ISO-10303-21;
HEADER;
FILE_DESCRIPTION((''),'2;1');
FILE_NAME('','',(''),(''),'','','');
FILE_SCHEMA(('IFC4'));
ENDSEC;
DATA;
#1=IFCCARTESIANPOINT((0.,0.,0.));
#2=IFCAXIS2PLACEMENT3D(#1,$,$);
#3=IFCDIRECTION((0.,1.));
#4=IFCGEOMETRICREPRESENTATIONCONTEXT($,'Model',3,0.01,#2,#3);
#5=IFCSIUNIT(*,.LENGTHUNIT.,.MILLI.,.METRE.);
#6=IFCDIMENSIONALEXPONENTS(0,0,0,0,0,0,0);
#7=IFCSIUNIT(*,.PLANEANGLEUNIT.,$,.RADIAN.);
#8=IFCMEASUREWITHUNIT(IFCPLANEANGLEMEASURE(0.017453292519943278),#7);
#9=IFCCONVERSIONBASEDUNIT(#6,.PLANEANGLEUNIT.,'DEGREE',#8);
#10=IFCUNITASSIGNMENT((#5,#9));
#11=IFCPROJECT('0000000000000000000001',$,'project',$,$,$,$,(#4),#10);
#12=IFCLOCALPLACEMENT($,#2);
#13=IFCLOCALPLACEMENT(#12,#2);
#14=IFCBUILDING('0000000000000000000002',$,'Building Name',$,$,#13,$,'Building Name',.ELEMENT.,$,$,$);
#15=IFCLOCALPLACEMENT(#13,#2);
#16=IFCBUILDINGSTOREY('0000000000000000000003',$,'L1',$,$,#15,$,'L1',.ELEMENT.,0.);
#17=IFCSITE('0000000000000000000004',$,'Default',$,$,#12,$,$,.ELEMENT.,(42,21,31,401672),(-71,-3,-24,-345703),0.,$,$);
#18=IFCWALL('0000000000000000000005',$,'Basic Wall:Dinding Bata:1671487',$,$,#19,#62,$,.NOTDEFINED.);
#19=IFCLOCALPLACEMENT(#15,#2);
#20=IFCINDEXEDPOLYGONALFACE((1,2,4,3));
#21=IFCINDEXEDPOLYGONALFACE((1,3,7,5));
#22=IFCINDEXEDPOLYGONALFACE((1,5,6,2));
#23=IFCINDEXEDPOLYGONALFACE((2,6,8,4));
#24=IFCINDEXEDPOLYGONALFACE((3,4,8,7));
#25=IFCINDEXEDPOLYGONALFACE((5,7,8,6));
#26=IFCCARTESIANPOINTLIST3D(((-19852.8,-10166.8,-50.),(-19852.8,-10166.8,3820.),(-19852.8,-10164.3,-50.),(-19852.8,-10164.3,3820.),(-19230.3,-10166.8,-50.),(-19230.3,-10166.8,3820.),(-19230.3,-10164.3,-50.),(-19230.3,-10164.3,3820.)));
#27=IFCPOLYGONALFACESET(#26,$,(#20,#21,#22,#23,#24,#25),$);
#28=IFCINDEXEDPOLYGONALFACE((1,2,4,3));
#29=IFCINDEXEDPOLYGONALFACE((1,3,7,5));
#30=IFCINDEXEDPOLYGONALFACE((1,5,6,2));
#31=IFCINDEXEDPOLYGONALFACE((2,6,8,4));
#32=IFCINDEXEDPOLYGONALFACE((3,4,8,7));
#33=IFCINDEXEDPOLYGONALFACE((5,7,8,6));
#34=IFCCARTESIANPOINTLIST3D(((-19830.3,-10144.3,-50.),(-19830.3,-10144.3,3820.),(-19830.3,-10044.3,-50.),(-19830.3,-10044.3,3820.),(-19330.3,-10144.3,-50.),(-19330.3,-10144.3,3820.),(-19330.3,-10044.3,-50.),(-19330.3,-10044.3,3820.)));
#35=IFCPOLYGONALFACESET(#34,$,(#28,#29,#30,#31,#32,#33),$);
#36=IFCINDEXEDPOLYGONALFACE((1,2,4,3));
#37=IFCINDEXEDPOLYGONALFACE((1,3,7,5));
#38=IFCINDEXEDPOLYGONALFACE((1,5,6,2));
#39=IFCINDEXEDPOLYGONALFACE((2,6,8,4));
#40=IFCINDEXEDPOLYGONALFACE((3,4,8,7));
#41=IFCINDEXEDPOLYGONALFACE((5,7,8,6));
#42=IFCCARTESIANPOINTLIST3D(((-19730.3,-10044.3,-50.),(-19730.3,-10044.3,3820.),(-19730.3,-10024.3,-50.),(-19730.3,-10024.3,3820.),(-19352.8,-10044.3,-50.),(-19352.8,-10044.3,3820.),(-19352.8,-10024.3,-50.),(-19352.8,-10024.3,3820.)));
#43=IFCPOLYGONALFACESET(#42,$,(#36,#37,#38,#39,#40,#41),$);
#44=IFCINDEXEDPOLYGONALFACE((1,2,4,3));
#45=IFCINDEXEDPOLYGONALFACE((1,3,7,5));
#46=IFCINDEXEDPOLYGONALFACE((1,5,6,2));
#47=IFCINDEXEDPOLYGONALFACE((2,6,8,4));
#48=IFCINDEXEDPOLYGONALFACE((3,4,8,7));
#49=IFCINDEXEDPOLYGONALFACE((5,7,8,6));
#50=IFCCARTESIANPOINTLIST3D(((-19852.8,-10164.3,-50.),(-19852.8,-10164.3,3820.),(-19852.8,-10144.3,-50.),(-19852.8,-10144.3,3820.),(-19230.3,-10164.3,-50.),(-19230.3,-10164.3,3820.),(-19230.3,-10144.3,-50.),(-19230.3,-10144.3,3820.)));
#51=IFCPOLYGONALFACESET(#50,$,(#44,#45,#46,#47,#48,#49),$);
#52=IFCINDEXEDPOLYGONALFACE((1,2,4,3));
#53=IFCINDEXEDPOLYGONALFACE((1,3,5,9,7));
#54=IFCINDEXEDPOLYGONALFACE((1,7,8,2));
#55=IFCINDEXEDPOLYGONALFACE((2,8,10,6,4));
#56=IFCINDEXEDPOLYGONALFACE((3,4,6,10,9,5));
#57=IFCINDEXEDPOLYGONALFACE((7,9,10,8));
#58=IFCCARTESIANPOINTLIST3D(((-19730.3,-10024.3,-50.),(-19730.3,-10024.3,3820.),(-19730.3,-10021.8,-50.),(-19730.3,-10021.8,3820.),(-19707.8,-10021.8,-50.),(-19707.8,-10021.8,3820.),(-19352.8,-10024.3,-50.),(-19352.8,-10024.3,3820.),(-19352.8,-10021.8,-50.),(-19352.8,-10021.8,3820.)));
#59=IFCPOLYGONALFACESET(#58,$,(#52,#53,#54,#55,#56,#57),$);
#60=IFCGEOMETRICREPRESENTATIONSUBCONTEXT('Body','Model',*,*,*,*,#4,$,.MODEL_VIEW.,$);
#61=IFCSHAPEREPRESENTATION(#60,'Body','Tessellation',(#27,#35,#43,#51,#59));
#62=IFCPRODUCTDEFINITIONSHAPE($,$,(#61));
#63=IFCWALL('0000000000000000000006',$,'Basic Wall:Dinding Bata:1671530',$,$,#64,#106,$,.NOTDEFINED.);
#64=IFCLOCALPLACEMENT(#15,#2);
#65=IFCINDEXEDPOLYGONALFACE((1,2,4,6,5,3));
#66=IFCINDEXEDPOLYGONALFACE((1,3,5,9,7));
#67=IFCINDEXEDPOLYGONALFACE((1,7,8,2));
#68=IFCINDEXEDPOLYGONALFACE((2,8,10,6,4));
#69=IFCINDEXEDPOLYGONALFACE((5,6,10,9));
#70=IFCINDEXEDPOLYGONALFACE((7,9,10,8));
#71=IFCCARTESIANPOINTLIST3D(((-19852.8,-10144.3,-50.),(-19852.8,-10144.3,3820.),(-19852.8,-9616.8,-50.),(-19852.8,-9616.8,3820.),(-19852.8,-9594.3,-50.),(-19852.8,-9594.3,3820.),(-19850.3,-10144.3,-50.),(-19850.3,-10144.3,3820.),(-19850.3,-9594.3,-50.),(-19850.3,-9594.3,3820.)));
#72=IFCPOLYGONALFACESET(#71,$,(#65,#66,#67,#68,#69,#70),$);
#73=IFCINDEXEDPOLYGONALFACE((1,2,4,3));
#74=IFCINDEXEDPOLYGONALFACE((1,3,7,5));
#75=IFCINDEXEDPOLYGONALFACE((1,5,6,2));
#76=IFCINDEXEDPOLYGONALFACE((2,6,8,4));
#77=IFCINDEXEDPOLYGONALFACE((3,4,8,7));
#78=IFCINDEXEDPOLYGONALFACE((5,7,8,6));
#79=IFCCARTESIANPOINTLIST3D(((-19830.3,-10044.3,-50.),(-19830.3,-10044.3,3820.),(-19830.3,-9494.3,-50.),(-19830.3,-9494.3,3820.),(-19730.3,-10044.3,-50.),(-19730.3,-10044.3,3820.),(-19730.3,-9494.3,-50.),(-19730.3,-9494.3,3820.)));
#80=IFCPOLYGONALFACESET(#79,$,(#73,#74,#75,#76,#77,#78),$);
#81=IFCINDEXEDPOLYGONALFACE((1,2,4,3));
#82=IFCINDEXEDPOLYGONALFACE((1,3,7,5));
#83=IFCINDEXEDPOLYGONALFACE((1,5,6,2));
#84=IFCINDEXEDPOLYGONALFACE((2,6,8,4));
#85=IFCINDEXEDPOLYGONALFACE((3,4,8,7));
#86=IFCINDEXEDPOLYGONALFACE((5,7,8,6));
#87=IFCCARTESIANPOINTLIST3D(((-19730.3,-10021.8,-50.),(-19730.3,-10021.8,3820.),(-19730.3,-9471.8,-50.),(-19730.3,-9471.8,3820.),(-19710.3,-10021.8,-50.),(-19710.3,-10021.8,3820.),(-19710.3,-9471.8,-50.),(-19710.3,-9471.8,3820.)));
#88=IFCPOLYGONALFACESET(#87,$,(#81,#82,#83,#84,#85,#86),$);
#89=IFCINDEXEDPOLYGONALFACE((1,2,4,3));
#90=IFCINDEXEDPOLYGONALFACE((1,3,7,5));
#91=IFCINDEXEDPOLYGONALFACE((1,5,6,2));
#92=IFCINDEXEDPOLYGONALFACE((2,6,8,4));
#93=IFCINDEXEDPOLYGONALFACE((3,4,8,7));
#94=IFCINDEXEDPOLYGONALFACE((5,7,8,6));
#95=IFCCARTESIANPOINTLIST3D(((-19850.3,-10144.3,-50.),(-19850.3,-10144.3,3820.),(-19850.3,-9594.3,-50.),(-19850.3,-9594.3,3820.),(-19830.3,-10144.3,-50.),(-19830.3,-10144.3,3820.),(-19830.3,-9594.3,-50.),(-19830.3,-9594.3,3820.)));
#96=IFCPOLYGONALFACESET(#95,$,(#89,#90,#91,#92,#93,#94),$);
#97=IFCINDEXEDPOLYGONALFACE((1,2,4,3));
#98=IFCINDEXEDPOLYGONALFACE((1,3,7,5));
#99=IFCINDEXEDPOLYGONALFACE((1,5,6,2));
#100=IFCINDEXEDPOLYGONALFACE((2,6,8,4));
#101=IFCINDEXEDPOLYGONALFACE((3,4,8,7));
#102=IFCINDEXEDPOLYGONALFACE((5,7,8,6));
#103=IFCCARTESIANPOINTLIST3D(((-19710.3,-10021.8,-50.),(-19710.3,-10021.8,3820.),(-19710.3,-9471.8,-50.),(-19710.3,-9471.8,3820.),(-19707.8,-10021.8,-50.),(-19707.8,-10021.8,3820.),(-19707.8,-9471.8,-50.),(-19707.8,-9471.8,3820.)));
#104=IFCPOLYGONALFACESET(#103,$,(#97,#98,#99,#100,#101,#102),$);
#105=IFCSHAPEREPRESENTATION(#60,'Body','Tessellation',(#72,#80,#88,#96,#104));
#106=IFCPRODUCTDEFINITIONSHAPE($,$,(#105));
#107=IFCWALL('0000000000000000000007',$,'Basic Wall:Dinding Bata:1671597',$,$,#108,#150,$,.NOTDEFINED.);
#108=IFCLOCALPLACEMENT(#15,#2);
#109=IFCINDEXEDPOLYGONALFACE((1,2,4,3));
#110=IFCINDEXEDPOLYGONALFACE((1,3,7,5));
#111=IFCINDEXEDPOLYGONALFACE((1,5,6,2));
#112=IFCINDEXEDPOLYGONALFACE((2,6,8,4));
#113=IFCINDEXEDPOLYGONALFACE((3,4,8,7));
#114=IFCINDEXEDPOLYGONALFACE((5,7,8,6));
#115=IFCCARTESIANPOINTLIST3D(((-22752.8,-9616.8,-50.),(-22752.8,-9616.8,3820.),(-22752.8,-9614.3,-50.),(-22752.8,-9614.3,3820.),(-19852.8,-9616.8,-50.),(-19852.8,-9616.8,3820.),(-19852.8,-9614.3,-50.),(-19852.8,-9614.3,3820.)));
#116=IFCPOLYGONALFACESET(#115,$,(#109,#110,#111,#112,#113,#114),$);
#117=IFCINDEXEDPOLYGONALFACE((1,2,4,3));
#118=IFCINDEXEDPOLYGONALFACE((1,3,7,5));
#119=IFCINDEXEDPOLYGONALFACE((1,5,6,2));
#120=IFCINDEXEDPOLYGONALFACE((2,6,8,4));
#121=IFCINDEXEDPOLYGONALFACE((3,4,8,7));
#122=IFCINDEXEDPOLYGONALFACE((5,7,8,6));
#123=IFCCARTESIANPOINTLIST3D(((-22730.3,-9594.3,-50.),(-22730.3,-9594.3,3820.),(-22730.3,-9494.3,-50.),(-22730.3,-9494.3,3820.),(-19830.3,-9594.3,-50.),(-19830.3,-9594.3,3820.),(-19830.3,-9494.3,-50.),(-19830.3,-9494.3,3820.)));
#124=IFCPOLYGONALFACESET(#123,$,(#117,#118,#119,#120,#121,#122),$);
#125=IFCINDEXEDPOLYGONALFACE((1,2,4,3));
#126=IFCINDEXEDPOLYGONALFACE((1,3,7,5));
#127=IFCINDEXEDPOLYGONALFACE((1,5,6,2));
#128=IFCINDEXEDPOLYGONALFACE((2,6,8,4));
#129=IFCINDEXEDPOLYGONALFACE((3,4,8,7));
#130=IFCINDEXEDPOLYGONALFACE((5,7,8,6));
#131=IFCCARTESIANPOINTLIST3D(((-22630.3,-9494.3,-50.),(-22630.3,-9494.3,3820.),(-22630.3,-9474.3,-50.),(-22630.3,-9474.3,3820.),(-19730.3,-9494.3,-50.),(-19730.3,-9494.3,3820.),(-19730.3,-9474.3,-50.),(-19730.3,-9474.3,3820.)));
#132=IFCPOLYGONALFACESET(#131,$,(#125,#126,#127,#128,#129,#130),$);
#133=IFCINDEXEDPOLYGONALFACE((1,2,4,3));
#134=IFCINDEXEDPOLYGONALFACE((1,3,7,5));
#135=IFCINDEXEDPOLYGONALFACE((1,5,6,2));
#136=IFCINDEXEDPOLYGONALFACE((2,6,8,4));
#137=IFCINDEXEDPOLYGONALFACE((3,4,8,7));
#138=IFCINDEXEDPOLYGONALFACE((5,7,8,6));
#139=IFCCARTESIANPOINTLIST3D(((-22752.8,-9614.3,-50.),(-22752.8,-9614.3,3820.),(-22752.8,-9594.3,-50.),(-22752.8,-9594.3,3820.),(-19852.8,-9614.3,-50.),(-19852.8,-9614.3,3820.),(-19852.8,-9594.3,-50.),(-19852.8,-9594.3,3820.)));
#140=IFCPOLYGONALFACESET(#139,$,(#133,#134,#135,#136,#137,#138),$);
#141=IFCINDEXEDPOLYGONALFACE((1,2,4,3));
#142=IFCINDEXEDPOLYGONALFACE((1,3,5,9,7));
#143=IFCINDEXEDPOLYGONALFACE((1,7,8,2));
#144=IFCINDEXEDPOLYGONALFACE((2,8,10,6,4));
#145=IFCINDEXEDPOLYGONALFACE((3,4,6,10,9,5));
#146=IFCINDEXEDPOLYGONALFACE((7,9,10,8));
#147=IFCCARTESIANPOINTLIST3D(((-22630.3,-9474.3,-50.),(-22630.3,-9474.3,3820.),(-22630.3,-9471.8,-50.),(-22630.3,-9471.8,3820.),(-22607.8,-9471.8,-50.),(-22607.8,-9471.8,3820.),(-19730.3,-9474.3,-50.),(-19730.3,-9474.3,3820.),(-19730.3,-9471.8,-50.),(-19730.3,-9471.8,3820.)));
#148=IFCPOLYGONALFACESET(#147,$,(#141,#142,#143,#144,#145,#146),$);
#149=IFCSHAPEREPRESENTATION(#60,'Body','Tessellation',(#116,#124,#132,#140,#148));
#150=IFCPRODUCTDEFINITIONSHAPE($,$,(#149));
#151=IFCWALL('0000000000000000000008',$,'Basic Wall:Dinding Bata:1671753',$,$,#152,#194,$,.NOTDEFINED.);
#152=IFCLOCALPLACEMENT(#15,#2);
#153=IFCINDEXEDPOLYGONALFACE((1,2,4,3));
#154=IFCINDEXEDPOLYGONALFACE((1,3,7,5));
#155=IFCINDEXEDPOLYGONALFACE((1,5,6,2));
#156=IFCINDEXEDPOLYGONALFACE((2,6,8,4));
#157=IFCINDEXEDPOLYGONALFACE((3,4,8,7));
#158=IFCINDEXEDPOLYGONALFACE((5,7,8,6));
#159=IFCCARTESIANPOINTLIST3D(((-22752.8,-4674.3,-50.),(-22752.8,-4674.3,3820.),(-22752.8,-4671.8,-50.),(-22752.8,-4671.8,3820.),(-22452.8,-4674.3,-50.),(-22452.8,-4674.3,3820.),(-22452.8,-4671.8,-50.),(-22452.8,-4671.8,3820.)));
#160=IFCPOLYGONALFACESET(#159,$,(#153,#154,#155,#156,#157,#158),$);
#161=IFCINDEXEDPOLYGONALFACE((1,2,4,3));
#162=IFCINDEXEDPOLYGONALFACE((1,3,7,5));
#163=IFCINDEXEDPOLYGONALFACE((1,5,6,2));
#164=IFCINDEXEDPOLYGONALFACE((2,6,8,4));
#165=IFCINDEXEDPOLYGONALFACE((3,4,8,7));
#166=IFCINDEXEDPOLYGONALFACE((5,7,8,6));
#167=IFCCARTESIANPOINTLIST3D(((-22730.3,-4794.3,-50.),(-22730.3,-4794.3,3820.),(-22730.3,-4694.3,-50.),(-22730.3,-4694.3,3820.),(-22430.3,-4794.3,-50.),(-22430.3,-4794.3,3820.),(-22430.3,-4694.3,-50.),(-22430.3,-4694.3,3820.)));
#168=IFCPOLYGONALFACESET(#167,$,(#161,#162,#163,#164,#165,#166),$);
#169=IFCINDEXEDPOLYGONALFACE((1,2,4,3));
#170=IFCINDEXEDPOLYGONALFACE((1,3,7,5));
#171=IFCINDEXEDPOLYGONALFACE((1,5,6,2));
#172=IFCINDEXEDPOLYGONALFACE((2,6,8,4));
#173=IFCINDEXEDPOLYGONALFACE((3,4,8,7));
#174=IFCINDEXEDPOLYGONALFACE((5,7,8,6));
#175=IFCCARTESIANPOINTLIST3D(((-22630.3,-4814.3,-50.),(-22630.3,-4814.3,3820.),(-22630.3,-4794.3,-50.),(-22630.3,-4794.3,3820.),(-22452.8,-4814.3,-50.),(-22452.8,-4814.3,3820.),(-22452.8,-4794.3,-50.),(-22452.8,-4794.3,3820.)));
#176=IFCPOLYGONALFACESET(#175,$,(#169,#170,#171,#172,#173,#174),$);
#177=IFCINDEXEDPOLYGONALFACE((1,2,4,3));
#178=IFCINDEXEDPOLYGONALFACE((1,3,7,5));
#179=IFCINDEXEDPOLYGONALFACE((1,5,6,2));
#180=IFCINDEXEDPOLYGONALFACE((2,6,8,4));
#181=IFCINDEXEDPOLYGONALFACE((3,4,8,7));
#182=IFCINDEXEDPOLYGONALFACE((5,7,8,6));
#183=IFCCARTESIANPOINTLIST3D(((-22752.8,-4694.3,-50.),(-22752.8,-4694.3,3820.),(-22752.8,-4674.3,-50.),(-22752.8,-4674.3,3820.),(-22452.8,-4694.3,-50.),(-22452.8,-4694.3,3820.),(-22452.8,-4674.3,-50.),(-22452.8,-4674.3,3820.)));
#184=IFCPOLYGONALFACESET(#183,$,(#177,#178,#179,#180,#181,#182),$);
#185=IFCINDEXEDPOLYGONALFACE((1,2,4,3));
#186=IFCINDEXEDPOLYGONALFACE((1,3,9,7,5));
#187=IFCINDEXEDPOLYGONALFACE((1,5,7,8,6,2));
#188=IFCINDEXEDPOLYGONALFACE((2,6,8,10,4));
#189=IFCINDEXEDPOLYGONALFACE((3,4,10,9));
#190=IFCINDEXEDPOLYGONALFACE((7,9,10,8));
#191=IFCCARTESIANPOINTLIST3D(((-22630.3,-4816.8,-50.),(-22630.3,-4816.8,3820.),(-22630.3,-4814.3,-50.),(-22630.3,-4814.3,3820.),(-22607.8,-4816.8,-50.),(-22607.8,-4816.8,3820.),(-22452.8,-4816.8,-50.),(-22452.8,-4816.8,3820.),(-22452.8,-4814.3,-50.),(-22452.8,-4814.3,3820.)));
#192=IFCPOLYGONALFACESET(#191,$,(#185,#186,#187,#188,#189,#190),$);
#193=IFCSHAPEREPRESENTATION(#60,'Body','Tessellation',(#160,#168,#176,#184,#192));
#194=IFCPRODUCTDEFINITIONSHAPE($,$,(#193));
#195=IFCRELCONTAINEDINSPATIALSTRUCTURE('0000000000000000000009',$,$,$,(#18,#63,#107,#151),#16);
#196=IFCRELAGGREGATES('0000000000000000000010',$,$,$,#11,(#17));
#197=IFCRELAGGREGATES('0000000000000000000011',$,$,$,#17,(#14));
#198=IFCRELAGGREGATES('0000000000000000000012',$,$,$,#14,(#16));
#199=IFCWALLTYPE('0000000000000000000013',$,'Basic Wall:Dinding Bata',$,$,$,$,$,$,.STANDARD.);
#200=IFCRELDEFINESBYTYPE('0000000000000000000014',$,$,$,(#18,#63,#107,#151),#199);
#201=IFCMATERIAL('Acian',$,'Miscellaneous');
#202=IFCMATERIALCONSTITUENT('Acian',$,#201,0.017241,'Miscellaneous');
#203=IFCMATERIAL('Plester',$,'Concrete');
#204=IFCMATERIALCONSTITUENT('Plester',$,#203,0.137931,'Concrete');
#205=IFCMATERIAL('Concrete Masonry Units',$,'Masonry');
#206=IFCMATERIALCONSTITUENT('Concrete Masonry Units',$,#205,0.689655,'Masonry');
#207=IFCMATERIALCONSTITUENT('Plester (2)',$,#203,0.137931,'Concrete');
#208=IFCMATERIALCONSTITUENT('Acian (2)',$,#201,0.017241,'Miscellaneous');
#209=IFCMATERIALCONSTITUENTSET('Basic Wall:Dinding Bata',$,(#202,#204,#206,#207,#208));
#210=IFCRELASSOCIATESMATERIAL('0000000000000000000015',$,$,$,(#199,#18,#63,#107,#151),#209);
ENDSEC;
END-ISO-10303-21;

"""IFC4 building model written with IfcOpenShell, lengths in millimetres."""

from ifc_helpers import new_model, entity, si_unit, converted_unit, direction, frame, origin, place, context, subcontext, project, spatial, indexed_curve, outline, extrude, material, constituent, constituent_set, type_object, element, save


model = new_model("IFC4")

# Units and contexts
model_context = context("Model", 3, precision=0.01, world=origin(), true_north=direction((0.0, 1.0)))
body_context = subcontext(model_context, "Body", "Model", "MODEL_VIEW")
ifc_project = project(units=[si_unit("LENGTHUNIT", "METRE", prefix="MILLI"), converted_unit("PLANEANGLEUNIT", "DEGREE", entity("IfcPlaneAngleMeasure", 0.017453292519943278), si_unit("PLANEANGLEUNIT", "RADIAN"), dimensions=[0, 0, 0, 0, 0, 0, 0])], contexts=[model_context])

# Site, building, storey
site_placement = place(None, origin())
site = spatial("IfcSite", under=ifc_project, at=site_placement, Name="Default", CompositionType="ELEMENT", RefLatitude=(42, 21, 31, 401672), RefLongitude=(-71, -3, -24, -345703), RefElevation=0.0)
building_placement = place(site_placement, origin())
building = spatial("IfcBuilding", under=site, at=building_placement, Name="Building Name", LongName="Building Name", CompositionType="ELEMENT")
storey_placement = place(building_placement, origin())
storey = spatial("IfcBuildingStorey", under=building, at=storey_placement, Name="L1", LongName="L1", CompositionType="ELEMENT", Elevation=0.0)

# Walls
ifc_material_1 = material(Name="Acian", Category="Miscellaneous")
ifc_constituent_1 = constituent(ifc_material_1, Name="Acian", Category="Miscellaneous", fraction=0.017241)
ifc_material_2 = material(Name="Plester", Category="Concrete")
ifc_constituent_2 = constituent(ifc_material_2, Name="Plester", Category="Concrete", fraction=0.137931)
ifc_material_3 = material(Name="Concrete Masonry Units", Category="Masonry")
ifc_constituent_3 = constituent(ifc_material_3, Name="Concrete Masonry Units", Category="Masonry", fraction=0.689655)
ifc_constituent_4 = constituent(ifc_material_2, Name="Plester (2)", Category="Concrete", fraction=0.137931)
ifc_constituent_5 = constituent(ifc_material_1, Name="Acian (2)", Category="Miscellaneous", fraction=0.017241)
ifc_constituent_set = constituent_set(constituents=[ifc_constituent_1, ifc_constituent_2, ifc_constituent_3, ifc_constituent_4, ifc_constituent_5], Name="Basic Wall:Dinding Bata")
wall_type = type_object("IfcWallType", Name="Basic Wall:Dinding Bata", PredefinedType="STANDARD", material=ifc_constituent_set)
wall_1_placement = place(storey_placement, frame((-19352.8, -10094.3, -50.0), z_axis=(0.0, 0.0, 1.0), x_axis=(-1.0, 0.0, 0.0)))
element("IfcWall", 1, at=wall_1_placement, inside=storey, type_object=wall_type, material=ifc_constituent_set, Name="Basic Wall:Dinding Bata:1671487", PredefinedType="NOTDEFINED", context=body_context, shape_type="SweptSolid", body=[
    extrude(outline(indexed_curve([(-1.3, -311.2), (1.2, -311.2), (1.3, 311.2), (-1.2, 311.2), (-1.3, -311.2)], self_intersect=False)), frame((188.7, 71.2, 0.0), z_axis=(0.0, 0.0, 1.0), x_axis=(0.0, -1.0, 0.0)), (0.0, 0.0, 1.0), 3870.0),
    extrude(outline(indexed_curve([(-250.0, -50.0), (250.0, -50.0), (250.0, 50.0), (-250.0, 50.0), (-250.0, -50.0)], self_intersect=False)), frame((227.5, 0.0, 0.0)), (0.0, 0.0, 1.0), 3870.0),
    extrude(outline(indexed_curve([(-188.7, -10.0), (188.7, -10.0), (188.7, 10.0), (-188.7, 10.0), (-188.7, -10.0)], self_intersect=False)), frame((188.7, -60.0, 0.0)), (0.0, 0.0, 1.0), 3870.0),
    extrude(outline(indexed_curve([(-311.2, -10.0), (311.2, -10.0), (311.2, 10.0), (-311.2, 10.0), (-311.2, -10.0)], self_intersect=False)), frame((188.7, 60.0, 0.0)), (0.0, 0.0, 1.0), 3870.0),
    extrude(outline(indexed_curve([(133.0, -1.0), (155.5, -1.0), (155.5, 1.5), (-222.0, 1.5), (-222.0, -1.0), (133.0, -1.0)], self_intersect=False)), frame((222.0, -71.5, 0.0)), (0.0, 0.0, 1.0), 3870.0),
])
wall_2_placement = place(storey_placement, frame((-19780.3, -10021.8, -50.0), z_axis=(0.0, 0.0, 1.0), x_axis=(0.0, 1.0, 0.0)))
element("IfcWall", 2, at=wall_2_placement, inside=storey, type_object=wall_type, material=ifc_constituent_set, Name="Basic Wall:Dinding Bata:1671530", PredefinedType="NOTDEFINED", context=body_context, shape_type="SweptSolid", body=[
    extrude(outline(indexed_curve([(-202.0, -1.0), (325.5, -1.0), (325.5, 1.5), (-224.5, 1.5), (-224.5, -1.0), (-202.0, -1.0)], self_intersect=False)), frame((203.0, 71.5, 0.0), z_axis=(0.0, 0.0, 1.0), x_axis=(-1.0, 0.0, 0.0)), (0.0, 0.0, 1.0), 3870.0),
    extrude(outline(indexed_curve([(-275.0, -50.0), (275.0, -50.0), (275.0, 50.0), (-275.0, 50.0), (-275.0, -50.0)], self_intersect=False)), frame((252.5, 0.0, 0.0)), (0.0, 0.0, 1.0), 3870.0),
    extrude(outline(indexed_curve([(-275.0, -10.0), (275.0, -10.0), (275.0, 10.0), (-275.0, 10.0), (-275.0, -10.0)], self_intersect=False)), frame((275.0, -60.0, 0.0)), (0.0, 0.0, 1.0), 3870.0),
    extrude(outline(indexed_curve([(-275.0, -10.0), (275.0, -10.0), (275.0, 10.0), (-275.0, 10.0), (-275.0, -10.0)], self_intersect=False)), frame((152.5, 60.0, 0.0)), (0.0, 0.0, 1.0), 3870.0),
    extrude(outline(indexed_curve([(-1.2, -275.0), (1.2, -275.0), (1.2, 275.0), (-1.2, 275.0), (-1.2, -275.0)], self_intersect=False)), frame((275.0, -71.3, 0.0), z_axis=(0.0, 0.0, 1.0), x_axis=(0.0, 1.0, 0.0)), (0.0, 0.0, 1.0), 3870.0),
])
wall_3_placement = place(storey_placement, frame((-19852.8, -9544.3, -50.0), z_axis=(0.0, 0.0, 1.0), x_axis=(-1.0, 0.0, 0.0)))
element("IfcWall", 3, at=wall_3_placement, inside=storey, type_object=wall_type, material=ifc_constituent_set, Name="Basic Wall:Dinding Bata:1671597", PredefinedType="NOTDEFINED", context=body_context, shape_type="SweptSolid", body=[
    extrude(outline(indexed_curve([(-1.3, -1450.0), (1.2, -1450.0), (1.3, 1450.0), (-1.2, 1450.0), (-1.3, -1450.0)], self_intersect=False)), frame((1450.0, 71.3, 0.0), z_axis=(0.0, 0.0, 1.0), x_axis=(0.0, -1.0, 0.0)), (0.0, 0.0, 1.0), 3870.0),
    extrude(outline(indexed_curve([(-1450.0, -50.0), (1450.0, -50.0), (1450.0, 50.0), (-1450.0, 50.0), (-1450.0, -50.0)], self_intersect=False)), frame((1427.5, 0.0, 0.0)), (0.0, 0.0, 1.0), 3870.0),
    extrude(outline(indexed_curve([(-1450.0, -10.0), (1450.0, -10.0), (1450.0, 10.0), (-1450.0, 10.0), (-1450.0, -10.0)], self_intersect=False)), frame((1327.5, -60.0, 0.0)), (0.0, 0.0, 1.0), 3870.0),
    extrude(outline(indexed_curve([(-1450.0, -10.0), (1450.0, -10.0), (1450.0, 10.0), (-1450.0, 10.0), (-1450.0, -10.0)], self_intersect=False)), frame((1450.0, 60.0, 0.0)), (0.0, 0.0, 1.0), 3870.0),
    extrude(outline(indexed_curve([(1142.0, -1.0), (1164.5, -1.0), (1164.5, 1.5), (-1735.5, 1.5), (-1735.5, -1.0), (1142.0, -1.0)], self_intersect=False)), frame((1613.0, -71.5, 0.0)), (0.0, 0.0, 1.0), 3870.0),
])
wall_4_placement = place(storey_placement, frame((-22752.8, -4744.3, -50.0)))
element("IfcWall", 4, at=wall_4_placement, inside=storey, type_object=wall_type, material=ifc_constituent_set, Name="Basic Wall:Dinding Bata:1671753", PredefinedType="NOTDEFINED", context=body_context, shape_type="SweptSolid", body=[
    extrude(outline(indexed_curve([(-1.3, -150.0), (1.2, -150.0), (1.3, 150.0), (-1.2, 150.0), (-1.3, -150.0)], self_intersect=False)), frame((150.0, 71.3, 0.0), z_axis=(0.0, 0.0, 1.0), x_axis=(0.0, -1.0, 0.0)), (0.0, 0.0, 1.0), 3870.0),
    extrude(outline(indexed_curve([(-150.0, -50.0), (150.0, -50.0), (150.0, 50.0), (-150.0, 50.0), (-150.0, -50.0)], self_intersect=False)), frame((172.5, 0.0, 0.0)), (0.0, 0.0, 1.0), 3870.0),
    extrude(outline(indexed_curve([(-88.7, -10.0), (88.7, -10.0), (88.7, 10.0), (-88.7, 10.0), (-88.7, -10.0)], self_intersect=False)), frame((211.2, -60.0, 0.0)), (0.0, 0.0, 1.0), 3870.0),
    extrude(outline(indexed_curve([(-150.0, -10.0), (150.0, -10.0), (150.0, 10.0), (-150.0, 10.0), (-150.0, -10.0)], self_intersect=False)), frame((150.0, 60.0, 0.0)), (0.0, 0.0, 1.0), 3870.0),
    extrude(outline(indexed_curve([(-53.0, -1.0), (102.0, -1.0), (102.0, 1.5), (-75.5, 1.5), (-75.5, -1.0), (-53.0, -1.0)], self_intersect=False)), frame((198.0, -71.5, 0.0)), (0.0, 0.0, 1.0), 3870.0),
])

save(model, "model.ifc")
